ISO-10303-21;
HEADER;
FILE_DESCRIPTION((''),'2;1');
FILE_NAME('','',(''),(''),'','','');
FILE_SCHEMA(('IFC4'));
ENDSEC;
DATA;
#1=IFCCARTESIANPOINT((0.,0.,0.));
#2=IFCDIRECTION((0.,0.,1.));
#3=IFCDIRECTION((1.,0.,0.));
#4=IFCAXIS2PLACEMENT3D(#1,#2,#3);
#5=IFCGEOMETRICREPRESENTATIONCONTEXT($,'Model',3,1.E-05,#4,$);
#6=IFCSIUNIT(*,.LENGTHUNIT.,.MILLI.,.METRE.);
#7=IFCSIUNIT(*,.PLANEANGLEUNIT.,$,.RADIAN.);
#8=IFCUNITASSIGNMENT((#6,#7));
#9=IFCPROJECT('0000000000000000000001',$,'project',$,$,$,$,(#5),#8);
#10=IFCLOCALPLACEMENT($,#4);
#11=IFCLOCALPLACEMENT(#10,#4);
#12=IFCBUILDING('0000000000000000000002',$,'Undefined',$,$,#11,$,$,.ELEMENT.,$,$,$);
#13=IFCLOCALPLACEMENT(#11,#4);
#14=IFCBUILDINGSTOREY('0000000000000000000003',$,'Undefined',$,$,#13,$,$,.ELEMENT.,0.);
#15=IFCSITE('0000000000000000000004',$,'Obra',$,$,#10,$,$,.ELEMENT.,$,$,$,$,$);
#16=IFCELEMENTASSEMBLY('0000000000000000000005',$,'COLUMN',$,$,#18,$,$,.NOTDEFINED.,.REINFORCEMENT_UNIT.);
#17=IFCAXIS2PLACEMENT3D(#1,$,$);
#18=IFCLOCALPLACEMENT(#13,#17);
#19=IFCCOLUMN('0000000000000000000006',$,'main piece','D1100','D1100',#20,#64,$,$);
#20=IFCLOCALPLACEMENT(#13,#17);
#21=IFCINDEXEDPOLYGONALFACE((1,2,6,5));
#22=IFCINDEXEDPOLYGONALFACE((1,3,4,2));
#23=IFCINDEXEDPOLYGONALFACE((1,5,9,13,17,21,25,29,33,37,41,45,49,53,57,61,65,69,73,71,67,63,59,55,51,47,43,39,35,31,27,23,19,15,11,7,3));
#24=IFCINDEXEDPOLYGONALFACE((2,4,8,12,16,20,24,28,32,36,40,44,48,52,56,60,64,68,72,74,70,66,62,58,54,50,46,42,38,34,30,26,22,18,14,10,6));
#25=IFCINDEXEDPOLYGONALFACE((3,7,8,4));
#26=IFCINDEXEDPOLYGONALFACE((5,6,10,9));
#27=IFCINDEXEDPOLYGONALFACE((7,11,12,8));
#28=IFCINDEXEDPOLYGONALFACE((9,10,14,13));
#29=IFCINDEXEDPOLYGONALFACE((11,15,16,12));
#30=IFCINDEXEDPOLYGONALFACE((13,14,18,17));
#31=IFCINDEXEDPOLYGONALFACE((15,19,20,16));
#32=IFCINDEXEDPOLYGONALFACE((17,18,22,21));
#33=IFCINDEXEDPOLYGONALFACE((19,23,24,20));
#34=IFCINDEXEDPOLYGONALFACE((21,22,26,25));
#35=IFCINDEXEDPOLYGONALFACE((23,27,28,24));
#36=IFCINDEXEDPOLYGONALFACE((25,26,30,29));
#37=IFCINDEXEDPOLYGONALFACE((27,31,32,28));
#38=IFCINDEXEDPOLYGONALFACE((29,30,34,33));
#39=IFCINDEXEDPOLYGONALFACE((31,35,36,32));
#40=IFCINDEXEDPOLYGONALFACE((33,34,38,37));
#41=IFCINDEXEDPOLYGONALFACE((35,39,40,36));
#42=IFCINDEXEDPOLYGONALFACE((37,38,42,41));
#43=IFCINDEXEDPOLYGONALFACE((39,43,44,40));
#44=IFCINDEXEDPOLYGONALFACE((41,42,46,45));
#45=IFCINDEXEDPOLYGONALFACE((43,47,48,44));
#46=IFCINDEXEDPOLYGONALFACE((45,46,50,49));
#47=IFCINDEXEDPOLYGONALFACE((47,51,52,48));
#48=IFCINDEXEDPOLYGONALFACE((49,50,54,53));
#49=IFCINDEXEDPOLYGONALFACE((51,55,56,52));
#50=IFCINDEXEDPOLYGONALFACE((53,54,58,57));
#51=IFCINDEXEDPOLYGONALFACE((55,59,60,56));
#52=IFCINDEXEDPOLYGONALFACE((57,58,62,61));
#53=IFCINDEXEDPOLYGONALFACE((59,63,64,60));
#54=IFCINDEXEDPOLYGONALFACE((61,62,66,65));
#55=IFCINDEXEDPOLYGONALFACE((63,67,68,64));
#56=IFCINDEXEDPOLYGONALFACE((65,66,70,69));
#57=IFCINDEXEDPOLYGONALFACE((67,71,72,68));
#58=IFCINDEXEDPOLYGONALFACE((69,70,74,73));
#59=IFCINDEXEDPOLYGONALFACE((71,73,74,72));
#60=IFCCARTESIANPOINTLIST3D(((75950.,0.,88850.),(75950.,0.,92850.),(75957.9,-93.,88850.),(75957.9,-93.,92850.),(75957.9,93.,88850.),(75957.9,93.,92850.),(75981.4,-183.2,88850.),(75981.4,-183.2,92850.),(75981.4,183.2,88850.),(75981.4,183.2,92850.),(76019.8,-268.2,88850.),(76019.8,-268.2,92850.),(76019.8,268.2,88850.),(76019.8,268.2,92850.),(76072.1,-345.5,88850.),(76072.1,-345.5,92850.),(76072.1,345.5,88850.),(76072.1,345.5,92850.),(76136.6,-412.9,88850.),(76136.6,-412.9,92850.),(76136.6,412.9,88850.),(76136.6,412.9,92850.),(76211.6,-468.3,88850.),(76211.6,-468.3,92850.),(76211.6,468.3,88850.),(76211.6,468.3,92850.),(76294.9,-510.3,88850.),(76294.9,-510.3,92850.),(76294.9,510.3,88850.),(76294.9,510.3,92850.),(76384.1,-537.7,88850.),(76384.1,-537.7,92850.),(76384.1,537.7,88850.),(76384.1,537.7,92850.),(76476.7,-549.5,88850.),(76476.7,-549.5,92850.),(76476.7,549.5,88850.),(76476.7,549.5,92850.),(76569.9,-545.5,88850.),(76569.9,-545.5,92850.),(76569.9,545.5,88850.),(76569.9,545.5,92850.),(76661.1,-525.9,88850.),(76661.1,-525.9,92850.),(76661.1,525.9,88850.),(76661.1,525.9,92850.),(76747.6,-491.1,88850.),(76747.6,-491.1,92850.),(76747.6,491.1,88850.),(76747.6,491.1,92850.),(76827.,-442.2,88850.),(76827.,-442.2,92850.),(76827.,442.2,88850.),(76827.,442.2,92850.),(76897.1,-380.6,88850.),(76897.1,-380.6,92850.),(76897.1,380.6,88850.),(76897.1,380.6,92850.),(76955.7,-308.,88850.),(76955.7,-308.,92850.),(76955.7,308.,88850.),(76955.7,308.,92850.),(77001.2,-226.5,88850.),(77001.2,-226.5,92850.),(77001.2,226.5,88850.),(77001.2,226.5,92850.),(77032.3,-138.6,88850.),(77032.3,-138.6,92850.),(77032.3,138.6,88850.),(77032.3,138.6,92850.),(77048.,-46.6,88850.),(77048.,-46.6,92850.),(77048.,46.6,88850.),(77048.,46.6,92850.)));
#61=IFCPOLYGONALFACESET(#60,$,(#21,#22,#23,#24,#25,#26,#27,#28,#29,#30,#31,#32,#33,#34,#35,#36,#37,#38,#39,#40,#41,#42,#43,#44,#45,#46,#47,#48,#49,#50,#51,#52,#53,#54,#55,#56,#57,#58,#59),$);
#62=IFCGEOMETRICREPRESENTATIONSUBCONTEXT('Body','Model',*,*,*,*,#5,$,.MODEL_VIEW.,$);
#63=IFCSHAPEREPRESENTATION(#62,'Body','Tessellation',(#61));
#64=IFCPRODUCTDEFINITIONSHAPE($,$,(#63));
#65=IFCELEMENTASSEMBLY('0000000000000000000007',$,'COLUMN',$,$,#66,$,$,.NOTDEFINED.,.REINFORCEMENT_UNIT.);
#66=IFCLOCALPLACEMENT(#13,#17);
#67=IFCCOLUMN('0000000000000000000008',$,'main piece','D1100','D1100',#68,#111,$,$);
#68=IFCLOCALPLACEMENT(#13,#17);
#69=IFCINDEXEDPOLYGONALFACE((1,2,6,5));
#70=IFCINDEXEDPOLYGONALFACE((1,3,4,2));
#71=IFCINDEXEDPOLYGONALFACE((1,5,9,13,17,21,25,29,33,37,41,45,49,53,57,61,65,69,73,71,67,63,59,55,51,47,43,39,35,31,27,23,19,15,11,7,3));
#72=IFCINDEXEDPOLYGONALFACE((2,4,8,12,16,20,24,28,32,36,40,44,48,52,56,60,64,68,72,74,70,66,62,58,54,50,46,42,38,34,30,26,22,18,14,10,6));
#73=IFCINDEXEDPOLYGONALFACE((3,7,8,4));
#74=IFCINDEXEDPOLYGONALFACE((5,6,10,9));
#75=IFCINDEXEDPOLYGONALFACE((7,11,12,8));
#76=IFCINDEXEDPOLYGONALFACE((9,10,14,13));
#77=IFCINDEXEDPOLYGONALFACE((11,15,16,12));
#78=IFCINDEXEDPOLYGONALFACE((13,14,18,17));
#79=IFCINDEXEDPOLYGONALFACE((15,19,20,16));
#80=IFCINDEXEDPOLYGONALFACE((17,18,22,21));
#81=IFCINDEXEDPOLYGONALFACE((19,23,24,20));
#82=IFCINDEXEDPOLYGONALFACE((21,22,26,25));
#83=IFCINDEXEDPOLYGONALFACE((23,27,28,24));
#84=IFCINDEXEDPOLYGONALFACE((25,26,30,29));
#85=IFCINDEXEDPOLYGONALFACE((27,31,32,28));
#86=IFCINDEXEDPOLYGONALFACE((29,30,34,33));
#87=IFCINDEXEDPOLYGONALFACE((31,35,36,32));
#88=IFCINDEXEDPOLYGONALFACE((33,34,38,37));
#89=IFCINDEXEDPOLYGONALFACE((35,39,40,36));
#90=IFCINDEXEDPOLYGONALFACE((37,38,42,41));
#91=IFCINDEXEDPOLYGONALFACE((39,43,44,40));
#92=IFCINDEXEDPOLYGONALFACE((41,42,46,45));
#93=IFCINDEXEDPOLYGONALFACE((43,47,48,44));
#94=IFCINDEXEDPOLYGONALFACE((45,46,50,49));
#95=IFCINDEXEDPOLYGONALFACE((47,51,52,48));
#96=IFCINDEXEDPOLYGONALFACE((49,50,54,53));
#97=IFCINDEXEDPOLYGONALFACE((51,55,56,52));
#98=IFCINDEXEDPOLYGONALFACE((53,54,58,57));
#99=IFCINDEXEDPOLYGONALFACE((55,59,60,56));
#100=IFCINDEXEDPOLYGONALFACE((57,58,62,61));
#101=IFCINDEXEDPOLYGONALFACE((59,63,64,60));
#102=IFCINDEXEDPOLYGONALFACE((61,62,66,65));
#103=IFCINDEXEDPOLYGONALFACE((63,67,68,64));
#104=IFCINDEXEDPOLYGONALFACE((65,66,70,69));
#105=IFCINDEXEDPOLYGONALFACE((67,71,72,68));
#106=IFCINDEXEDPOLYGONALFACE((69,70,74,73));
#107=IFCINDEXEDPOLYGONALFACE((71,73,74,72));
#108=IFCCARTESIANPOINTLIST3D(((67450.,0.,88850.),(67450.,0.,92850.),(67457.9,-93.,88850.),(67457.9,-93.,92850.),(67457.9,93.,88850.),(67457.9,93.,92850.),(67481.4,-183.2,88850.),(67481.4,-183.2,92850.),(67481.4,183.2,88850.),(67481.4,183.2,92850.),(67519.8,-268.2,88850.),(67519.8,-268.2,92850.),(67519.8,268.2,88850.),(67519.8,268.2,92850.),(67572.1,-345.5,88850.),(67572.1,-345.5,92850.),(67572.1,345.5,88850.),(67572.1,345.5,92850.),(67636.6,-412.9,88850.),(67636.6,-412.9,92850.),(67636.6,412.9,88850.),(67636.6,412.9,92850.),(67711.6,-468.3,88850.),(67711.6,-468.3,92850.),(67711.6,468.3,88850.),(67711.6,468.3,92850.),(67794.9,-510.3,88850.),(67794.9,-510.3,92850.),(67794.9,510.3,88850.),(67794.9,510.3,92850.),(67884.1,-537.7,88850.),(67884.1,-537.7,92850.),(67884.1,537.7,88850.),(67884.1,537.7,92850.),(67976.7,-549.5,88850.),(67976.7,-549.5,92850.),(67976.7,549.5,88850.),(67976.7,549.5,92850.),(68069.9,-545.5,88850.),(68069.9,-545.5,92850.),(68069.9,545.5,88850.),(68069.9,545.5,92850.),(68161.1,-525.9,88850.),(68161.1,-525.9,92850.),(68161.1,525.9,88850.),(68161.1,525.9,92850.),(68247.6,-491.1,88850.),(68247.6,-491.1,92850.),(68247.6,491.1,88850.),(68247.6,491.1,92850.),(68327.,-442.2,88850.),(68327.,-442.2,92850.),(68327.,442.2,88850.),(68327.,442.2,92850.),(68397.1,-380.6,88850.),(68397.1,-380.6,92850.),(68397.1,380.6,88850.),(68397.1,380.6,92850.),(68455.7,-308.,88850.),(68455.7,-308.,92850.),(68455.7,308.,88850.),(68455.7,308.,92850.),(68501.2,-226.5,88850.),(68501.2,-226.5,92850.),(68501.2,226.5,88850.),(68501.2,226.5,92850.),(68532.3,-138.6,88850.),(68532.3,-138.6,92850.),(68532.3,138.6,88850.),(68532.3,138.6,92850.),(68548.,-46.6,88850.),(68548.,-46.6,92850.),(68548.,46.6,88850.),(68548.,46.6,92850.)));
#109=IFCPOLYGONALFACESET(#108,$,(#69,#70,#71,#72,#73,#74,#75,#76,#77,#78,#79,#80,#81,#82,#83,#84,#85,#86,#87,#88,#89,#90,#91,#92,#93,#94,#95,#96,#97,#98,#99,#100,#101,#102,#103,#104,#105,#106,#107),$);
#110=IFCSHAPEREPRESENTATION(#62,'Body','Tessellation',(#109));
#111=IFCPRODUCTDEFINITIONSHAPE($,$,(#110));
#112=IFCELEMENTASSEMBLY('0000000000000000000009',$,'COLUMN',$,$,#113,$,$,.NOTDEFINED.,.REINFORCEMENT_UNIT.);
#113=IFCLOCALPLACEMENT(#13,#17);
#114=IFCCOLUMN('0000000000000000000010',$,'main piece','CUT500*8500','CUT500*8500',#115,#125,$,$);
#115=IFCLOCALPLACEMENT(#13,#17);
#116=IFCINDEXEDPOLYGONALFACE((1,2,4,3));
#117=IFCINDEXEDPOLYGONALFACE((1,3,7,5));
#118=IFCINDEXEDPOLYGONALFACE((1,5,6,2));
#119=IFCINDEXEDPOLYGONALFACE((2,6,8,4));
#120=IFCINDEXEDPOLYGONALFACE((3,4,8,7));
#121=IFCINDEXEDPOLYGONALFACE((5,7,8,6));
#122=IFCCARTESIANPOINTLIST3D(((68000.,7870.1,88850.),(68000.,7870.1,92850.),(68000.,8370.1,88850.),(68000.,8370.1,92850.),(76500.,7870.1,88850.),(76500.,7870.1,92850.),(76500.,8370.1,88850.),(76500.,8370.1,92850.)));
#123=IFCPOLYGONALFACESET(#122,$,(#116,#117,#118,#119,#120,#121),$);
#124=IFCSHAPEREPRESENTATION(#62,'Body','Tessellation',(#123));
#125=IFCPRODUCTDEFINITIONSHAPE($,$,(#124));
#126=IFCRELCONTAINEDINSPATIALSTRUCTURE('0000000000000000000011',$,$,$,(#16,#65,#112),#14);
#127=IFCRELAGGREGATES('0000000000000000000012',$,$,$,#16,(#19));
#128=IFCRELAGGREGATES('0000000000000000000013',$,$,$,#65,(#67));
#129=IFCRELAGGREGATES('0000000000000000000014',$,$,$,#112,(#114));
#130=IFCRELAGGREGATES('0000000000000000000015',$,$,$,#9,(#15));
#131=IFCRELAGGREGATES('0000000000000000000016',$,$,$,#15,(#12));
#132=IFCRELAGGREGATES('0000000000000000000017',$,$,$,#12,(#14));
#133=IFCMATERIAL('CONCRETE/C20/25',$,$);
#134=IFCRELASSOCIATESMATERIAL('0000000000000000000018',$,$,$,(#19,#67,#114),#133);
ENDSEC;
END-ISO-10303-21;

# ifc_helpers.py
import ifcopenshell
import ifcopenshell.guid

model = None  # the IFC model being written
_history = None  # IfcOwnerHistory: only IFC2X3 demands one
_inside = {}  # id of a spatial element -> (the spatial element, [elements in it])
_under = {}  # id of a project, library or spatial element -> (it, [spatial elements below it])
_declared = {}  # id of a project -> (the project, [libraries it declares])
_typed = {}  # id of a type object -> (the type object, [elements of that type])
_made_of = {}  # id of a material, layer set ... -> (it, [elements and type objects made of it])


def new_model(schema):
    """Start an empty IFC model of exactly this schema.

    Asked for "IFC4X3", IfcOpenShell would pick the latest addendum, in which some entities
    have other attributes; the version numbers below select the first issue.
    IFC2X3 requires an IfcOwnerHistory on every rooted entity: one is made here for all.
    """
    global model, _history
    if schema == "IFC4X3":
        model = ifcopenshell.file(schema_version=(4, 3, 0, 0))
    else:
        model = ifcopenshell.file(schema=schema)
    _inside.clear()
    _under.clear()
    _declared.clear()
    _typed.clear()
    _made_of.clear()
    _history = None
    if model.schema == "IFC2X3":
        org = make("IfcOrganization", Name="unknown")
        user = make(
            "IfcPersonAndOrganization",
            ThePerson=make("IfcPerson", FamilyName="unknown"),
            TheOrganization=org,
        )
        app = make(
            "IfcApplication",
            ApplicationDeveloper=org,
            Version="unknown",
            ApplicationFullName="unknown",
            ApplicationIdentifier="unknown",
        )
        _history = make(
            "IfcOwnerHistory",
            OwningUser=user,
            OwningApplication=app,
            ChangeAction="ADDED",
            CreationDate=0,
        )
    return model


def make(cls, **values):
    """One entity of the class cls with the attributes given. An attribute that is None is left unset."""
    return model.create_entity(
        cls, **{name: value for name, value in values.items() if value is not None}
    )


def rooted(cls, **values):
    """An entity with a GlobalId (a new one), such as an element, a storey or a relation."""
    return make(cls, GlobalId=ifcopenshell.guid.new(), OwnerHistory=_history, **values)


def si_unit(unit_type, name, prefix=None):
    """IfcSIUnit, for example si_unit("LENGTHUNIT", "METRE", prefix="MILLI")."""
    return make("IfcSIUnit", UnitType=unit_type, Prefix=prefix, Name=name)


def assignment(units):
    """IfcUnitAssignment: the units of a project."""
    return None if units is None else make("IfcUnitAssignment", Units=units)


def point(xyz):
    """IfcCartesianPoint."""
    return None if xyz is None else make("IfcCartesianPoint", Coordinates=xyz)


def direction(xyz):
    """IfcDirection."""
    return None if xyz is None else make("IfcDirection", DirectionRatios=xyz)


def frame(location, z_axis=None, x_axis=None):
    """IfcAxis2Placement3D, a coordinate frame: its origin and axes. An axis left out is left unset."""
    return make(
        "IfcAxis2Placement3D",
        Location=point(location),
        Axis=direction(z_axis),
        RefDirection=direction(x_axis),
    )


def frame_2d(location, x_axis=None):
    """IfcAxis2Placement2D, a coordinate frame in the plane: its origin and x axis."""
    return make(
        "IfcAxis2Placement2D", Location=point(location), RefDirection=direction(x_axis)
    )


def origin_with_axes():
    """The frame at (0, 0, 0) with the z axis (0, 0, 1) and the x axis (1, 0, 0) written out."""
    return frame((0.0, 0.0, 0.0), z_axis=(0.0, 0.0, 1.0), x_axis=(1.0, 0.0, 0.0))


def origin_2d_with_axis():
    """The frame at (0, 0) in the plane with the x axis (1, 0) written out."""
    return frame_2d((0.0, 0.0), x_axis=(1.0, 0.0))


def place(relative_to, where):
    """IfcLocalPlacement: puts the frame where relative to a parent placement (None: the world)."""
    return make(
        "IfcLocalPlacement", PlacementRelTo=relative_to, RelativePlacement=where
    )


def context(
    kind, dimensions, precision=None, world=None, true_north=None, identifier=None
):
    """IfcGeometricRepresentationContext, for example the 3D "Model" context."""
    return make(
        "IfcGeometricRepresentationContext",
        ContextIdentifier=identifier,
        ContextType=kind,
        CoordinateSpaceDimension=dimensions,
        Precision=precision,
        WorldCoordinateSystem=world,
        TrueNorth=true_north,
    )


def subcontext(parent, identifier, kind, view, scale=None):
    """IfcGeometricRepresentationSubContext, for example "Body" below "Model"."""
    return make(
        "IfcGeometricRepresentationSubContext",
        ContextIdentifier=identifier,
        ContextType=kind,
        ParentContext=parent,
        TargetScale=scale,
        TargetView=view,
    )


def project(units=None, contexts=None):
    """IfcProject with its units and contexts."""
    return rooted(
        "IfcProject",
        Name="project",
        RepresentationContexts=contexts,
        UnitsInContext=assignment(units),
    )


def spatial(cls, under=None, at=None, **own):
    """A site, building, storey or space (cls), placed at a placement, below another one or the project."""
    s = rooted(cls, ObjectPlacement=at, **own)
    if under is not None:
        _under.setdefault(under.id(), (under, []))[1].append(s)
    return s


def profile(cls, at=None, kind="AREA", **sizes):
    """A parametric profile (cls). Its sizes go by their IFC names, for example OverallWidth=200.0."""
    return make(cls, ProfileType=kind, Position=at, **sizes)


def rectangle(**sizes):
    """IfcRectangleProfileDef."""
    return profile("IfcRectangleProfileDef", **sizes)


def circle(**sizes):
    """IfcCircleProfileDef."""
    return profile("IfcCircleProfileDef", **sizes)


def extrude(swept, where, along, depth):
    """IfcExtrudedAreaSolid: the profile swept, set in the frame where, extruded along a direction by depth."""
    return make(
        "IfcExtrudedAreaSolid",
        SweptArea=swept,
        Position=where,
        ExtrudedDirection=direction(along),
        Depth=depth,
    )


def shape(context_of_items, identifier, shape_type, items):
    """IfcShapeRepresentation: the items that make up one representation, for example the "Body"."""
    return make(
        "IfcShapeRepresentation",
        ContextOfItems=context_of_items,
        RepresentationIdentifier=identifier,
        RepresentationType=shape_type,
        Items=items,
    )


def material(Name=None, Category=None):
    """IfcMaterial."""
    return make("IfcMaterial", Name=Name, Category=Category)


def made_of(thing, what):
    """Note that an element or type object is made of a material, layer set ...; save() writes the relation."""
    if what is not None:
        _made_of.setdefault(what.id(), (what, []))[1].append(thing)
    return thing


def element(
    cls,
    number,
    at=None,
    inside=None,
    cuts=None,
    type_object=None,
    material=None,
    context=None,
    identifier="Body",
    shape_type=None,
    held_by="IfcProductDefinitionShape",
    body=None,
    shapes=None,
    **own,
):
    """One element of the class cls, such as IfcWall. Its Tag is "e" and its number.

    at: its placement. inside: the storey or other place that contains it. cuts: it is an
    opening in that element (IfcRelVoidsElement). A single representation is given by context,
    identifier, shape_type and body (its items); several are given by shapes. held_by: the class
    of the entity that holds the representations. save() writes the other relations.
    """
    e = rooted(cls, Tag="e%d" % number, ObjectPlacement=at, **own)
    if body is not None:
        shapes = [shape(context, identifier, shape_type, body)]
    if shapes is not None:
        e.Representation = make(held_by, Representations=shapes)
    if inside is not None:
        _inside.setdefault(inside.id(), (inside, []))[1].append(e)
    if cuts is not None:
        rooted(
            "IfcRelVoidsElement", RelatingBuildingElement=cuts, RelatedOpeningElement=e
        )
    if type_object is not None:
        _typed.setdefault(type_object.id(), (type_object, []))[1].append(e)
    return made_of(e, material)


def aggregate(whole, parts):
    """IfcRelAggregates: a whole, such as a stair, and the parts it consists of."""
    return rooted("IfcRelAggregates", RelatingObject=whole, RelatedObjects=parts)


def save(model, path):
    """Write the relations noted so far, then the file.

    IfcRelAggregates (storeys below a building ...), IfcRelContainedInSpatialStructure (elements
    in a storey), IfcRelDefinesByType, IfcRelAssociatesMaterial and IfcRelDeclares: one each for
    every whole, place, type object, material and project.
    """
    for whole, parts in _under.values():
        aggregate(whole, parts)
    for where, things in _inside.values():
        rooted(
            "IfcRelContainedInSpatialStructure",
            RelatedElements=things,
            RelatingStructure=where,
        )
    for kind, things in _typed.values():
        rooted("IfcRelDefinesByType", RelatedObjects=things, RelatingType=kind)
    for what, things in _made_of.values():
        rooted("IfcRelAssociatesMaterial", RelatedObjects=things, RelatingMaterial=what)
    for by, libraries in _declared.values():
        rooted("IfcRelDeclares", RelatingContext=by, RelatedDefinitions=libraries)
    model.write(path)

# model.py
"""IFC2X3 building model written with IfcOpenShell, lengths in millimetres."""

from ifc_helpers import new_model, si_unit, frame, origin_with_axes, origin_2d_with_axis, place, context, subcontext, project, spatial, rectangle, circle, extrude, material, element, aggregate, save


model = new_model("IFC2X3")

# Units and contexts
model_context = context("Model", 3, precision=1e-05, world=origin_with_axes())
body_context = subcontext(model_context, "Body", "Model", "MODEL_VIEW")
ifc_project = project(units=[si_unit("LENGTHUNIT", "METRE", prefix="MILLI"), si_unit("PLANEANGLEUNIT", "RADIAN")], contexts=[model_context])

# Site, building, storey
site_placement = place(None, origin_with_axes())
site = spatial("IfcSite", under=ifc_project, at=site_placement, Name="Obra", CompositionType="ELEMENT")
building_placement = place(site_placement, origin_with_axes())
building = spatial("IfcBuilding", under=site, at=building_placement, Name="Undefined", CompositionType="ELEMENT")
storey_placement = place(building_placement, origin_with_axes())
storey = spatial("IfcBuildingStorey", under=building, at=storey_placement, Name="Undefined", CompositionType="ELEMENT", Elevation=0.0)

# Element assemblies, columns
assembly_1_placement = place(storey_placement, origin_with_axes())
assembly_1 = element("IfcElementAssembly", 1, at=assembly_1_placement, inside=storey, Name="COLUMN", AssemblyPlace="NOTDEFINED", PredefinedType="REINFORCEMENT_UNIT")
ifc_material_1 = material(Name="CONCRETE/C20/25")
column_1_placement = place(assembly_1_placement, frame((76500.0, 0.0, 88850.0), z_axis=(0.0, 0.0, 1.0), x_axis=(0.0, 1.0, 0.0)))
column_1 = element("IfcColumn", 2, at=column_1_placement, material=ifc_material_1, Name="main piece", Description="D1100", ObjectType="D1100", context=body_context, shape_type="SweptSolid", body=[
    extrude(circle(Radius=550.0, at=origin_2d_with_axis()), frame((0.0, 0.0, 4000.0), z_axis=(0.0, 0.0, -1.0), x_axis=(0.0, 1.0, 0.0)), (0.0, 0.0, 1.0), 4000.0),
])
aggregate(assembly_1, [column_1])
assembly_2_placement = place(storey_placement, origin_with_axes())
assembly_2 = element("IfcElementAssembly", 3, at=assembly_2_placement, inside=storey, Name="COLUMN", AssemblyPlace="NOTDEFINED", PredefinedType="REINFORCEMENT_UNIT")
column_2_placement = place(assembly_2_placement, frame((68000.0, 0.0, 88850.0), z_axis=(0.0, 0.0, 1.0), x_axis=(0.0, 1.0, 0.0)))
column_2 = element("IfcColumn", 4, at=column_2_placement, material=ifc_material_1, Name="main piece", Description="D1100", ObjectType="D1100", context=body_context, shape_type="SweptSolid", body=[
    extrude(circle(Radius=550.0, at=origin_2d_with_axis()), frame((0.0, 0.0, 4000.0), z_axis=(0.0, 0.0, -1.0), x_axis=(0.0, 1.0, 0.0)), (0.0, 0.0, 1.0), 4000.0),
])
aggregate(assembly_2, [column_2])
assembly_3_placement = place(storey_placement, origin_with_axes())
assembly_3 = element("IfcElementAssembly", 5, at=assembly_3_placement, inside=storey, Name="COLUMN", AssemblyPlace="NOTDEFINED", PredefinedType="REINFORCEMENT_UNIT")
column_3_placement = place(assembly_3_placement, frame((72250.0, 8120.1, 88850.0), z_axis=(0.0, 0.0, 1.0), x_axis=(-1.0, 0.0, 0.0)))
column_3 = element("IfcColumn", 6, at=column_3_placement, material=ifc_material_1, Name="main piece", Description="CUT500*8500", ObjectType="CUT500*8500", context=body_context, shape_type="SweptSolid", body=[
    extrude(rectangle(XDim=500.0, YDim=8500.0, at=origin_2d_with_axis()), frame((0.0, 0.0, 4000.0), z_axis=(0.0, 0.0, -1.0), x_axis=(0.0, 1.0, 0.0)), (0.0, 0.0, 1.0), 4000.0),
])
aggregate(assembly_3, [column_3])

save(model, "model.ifc")
